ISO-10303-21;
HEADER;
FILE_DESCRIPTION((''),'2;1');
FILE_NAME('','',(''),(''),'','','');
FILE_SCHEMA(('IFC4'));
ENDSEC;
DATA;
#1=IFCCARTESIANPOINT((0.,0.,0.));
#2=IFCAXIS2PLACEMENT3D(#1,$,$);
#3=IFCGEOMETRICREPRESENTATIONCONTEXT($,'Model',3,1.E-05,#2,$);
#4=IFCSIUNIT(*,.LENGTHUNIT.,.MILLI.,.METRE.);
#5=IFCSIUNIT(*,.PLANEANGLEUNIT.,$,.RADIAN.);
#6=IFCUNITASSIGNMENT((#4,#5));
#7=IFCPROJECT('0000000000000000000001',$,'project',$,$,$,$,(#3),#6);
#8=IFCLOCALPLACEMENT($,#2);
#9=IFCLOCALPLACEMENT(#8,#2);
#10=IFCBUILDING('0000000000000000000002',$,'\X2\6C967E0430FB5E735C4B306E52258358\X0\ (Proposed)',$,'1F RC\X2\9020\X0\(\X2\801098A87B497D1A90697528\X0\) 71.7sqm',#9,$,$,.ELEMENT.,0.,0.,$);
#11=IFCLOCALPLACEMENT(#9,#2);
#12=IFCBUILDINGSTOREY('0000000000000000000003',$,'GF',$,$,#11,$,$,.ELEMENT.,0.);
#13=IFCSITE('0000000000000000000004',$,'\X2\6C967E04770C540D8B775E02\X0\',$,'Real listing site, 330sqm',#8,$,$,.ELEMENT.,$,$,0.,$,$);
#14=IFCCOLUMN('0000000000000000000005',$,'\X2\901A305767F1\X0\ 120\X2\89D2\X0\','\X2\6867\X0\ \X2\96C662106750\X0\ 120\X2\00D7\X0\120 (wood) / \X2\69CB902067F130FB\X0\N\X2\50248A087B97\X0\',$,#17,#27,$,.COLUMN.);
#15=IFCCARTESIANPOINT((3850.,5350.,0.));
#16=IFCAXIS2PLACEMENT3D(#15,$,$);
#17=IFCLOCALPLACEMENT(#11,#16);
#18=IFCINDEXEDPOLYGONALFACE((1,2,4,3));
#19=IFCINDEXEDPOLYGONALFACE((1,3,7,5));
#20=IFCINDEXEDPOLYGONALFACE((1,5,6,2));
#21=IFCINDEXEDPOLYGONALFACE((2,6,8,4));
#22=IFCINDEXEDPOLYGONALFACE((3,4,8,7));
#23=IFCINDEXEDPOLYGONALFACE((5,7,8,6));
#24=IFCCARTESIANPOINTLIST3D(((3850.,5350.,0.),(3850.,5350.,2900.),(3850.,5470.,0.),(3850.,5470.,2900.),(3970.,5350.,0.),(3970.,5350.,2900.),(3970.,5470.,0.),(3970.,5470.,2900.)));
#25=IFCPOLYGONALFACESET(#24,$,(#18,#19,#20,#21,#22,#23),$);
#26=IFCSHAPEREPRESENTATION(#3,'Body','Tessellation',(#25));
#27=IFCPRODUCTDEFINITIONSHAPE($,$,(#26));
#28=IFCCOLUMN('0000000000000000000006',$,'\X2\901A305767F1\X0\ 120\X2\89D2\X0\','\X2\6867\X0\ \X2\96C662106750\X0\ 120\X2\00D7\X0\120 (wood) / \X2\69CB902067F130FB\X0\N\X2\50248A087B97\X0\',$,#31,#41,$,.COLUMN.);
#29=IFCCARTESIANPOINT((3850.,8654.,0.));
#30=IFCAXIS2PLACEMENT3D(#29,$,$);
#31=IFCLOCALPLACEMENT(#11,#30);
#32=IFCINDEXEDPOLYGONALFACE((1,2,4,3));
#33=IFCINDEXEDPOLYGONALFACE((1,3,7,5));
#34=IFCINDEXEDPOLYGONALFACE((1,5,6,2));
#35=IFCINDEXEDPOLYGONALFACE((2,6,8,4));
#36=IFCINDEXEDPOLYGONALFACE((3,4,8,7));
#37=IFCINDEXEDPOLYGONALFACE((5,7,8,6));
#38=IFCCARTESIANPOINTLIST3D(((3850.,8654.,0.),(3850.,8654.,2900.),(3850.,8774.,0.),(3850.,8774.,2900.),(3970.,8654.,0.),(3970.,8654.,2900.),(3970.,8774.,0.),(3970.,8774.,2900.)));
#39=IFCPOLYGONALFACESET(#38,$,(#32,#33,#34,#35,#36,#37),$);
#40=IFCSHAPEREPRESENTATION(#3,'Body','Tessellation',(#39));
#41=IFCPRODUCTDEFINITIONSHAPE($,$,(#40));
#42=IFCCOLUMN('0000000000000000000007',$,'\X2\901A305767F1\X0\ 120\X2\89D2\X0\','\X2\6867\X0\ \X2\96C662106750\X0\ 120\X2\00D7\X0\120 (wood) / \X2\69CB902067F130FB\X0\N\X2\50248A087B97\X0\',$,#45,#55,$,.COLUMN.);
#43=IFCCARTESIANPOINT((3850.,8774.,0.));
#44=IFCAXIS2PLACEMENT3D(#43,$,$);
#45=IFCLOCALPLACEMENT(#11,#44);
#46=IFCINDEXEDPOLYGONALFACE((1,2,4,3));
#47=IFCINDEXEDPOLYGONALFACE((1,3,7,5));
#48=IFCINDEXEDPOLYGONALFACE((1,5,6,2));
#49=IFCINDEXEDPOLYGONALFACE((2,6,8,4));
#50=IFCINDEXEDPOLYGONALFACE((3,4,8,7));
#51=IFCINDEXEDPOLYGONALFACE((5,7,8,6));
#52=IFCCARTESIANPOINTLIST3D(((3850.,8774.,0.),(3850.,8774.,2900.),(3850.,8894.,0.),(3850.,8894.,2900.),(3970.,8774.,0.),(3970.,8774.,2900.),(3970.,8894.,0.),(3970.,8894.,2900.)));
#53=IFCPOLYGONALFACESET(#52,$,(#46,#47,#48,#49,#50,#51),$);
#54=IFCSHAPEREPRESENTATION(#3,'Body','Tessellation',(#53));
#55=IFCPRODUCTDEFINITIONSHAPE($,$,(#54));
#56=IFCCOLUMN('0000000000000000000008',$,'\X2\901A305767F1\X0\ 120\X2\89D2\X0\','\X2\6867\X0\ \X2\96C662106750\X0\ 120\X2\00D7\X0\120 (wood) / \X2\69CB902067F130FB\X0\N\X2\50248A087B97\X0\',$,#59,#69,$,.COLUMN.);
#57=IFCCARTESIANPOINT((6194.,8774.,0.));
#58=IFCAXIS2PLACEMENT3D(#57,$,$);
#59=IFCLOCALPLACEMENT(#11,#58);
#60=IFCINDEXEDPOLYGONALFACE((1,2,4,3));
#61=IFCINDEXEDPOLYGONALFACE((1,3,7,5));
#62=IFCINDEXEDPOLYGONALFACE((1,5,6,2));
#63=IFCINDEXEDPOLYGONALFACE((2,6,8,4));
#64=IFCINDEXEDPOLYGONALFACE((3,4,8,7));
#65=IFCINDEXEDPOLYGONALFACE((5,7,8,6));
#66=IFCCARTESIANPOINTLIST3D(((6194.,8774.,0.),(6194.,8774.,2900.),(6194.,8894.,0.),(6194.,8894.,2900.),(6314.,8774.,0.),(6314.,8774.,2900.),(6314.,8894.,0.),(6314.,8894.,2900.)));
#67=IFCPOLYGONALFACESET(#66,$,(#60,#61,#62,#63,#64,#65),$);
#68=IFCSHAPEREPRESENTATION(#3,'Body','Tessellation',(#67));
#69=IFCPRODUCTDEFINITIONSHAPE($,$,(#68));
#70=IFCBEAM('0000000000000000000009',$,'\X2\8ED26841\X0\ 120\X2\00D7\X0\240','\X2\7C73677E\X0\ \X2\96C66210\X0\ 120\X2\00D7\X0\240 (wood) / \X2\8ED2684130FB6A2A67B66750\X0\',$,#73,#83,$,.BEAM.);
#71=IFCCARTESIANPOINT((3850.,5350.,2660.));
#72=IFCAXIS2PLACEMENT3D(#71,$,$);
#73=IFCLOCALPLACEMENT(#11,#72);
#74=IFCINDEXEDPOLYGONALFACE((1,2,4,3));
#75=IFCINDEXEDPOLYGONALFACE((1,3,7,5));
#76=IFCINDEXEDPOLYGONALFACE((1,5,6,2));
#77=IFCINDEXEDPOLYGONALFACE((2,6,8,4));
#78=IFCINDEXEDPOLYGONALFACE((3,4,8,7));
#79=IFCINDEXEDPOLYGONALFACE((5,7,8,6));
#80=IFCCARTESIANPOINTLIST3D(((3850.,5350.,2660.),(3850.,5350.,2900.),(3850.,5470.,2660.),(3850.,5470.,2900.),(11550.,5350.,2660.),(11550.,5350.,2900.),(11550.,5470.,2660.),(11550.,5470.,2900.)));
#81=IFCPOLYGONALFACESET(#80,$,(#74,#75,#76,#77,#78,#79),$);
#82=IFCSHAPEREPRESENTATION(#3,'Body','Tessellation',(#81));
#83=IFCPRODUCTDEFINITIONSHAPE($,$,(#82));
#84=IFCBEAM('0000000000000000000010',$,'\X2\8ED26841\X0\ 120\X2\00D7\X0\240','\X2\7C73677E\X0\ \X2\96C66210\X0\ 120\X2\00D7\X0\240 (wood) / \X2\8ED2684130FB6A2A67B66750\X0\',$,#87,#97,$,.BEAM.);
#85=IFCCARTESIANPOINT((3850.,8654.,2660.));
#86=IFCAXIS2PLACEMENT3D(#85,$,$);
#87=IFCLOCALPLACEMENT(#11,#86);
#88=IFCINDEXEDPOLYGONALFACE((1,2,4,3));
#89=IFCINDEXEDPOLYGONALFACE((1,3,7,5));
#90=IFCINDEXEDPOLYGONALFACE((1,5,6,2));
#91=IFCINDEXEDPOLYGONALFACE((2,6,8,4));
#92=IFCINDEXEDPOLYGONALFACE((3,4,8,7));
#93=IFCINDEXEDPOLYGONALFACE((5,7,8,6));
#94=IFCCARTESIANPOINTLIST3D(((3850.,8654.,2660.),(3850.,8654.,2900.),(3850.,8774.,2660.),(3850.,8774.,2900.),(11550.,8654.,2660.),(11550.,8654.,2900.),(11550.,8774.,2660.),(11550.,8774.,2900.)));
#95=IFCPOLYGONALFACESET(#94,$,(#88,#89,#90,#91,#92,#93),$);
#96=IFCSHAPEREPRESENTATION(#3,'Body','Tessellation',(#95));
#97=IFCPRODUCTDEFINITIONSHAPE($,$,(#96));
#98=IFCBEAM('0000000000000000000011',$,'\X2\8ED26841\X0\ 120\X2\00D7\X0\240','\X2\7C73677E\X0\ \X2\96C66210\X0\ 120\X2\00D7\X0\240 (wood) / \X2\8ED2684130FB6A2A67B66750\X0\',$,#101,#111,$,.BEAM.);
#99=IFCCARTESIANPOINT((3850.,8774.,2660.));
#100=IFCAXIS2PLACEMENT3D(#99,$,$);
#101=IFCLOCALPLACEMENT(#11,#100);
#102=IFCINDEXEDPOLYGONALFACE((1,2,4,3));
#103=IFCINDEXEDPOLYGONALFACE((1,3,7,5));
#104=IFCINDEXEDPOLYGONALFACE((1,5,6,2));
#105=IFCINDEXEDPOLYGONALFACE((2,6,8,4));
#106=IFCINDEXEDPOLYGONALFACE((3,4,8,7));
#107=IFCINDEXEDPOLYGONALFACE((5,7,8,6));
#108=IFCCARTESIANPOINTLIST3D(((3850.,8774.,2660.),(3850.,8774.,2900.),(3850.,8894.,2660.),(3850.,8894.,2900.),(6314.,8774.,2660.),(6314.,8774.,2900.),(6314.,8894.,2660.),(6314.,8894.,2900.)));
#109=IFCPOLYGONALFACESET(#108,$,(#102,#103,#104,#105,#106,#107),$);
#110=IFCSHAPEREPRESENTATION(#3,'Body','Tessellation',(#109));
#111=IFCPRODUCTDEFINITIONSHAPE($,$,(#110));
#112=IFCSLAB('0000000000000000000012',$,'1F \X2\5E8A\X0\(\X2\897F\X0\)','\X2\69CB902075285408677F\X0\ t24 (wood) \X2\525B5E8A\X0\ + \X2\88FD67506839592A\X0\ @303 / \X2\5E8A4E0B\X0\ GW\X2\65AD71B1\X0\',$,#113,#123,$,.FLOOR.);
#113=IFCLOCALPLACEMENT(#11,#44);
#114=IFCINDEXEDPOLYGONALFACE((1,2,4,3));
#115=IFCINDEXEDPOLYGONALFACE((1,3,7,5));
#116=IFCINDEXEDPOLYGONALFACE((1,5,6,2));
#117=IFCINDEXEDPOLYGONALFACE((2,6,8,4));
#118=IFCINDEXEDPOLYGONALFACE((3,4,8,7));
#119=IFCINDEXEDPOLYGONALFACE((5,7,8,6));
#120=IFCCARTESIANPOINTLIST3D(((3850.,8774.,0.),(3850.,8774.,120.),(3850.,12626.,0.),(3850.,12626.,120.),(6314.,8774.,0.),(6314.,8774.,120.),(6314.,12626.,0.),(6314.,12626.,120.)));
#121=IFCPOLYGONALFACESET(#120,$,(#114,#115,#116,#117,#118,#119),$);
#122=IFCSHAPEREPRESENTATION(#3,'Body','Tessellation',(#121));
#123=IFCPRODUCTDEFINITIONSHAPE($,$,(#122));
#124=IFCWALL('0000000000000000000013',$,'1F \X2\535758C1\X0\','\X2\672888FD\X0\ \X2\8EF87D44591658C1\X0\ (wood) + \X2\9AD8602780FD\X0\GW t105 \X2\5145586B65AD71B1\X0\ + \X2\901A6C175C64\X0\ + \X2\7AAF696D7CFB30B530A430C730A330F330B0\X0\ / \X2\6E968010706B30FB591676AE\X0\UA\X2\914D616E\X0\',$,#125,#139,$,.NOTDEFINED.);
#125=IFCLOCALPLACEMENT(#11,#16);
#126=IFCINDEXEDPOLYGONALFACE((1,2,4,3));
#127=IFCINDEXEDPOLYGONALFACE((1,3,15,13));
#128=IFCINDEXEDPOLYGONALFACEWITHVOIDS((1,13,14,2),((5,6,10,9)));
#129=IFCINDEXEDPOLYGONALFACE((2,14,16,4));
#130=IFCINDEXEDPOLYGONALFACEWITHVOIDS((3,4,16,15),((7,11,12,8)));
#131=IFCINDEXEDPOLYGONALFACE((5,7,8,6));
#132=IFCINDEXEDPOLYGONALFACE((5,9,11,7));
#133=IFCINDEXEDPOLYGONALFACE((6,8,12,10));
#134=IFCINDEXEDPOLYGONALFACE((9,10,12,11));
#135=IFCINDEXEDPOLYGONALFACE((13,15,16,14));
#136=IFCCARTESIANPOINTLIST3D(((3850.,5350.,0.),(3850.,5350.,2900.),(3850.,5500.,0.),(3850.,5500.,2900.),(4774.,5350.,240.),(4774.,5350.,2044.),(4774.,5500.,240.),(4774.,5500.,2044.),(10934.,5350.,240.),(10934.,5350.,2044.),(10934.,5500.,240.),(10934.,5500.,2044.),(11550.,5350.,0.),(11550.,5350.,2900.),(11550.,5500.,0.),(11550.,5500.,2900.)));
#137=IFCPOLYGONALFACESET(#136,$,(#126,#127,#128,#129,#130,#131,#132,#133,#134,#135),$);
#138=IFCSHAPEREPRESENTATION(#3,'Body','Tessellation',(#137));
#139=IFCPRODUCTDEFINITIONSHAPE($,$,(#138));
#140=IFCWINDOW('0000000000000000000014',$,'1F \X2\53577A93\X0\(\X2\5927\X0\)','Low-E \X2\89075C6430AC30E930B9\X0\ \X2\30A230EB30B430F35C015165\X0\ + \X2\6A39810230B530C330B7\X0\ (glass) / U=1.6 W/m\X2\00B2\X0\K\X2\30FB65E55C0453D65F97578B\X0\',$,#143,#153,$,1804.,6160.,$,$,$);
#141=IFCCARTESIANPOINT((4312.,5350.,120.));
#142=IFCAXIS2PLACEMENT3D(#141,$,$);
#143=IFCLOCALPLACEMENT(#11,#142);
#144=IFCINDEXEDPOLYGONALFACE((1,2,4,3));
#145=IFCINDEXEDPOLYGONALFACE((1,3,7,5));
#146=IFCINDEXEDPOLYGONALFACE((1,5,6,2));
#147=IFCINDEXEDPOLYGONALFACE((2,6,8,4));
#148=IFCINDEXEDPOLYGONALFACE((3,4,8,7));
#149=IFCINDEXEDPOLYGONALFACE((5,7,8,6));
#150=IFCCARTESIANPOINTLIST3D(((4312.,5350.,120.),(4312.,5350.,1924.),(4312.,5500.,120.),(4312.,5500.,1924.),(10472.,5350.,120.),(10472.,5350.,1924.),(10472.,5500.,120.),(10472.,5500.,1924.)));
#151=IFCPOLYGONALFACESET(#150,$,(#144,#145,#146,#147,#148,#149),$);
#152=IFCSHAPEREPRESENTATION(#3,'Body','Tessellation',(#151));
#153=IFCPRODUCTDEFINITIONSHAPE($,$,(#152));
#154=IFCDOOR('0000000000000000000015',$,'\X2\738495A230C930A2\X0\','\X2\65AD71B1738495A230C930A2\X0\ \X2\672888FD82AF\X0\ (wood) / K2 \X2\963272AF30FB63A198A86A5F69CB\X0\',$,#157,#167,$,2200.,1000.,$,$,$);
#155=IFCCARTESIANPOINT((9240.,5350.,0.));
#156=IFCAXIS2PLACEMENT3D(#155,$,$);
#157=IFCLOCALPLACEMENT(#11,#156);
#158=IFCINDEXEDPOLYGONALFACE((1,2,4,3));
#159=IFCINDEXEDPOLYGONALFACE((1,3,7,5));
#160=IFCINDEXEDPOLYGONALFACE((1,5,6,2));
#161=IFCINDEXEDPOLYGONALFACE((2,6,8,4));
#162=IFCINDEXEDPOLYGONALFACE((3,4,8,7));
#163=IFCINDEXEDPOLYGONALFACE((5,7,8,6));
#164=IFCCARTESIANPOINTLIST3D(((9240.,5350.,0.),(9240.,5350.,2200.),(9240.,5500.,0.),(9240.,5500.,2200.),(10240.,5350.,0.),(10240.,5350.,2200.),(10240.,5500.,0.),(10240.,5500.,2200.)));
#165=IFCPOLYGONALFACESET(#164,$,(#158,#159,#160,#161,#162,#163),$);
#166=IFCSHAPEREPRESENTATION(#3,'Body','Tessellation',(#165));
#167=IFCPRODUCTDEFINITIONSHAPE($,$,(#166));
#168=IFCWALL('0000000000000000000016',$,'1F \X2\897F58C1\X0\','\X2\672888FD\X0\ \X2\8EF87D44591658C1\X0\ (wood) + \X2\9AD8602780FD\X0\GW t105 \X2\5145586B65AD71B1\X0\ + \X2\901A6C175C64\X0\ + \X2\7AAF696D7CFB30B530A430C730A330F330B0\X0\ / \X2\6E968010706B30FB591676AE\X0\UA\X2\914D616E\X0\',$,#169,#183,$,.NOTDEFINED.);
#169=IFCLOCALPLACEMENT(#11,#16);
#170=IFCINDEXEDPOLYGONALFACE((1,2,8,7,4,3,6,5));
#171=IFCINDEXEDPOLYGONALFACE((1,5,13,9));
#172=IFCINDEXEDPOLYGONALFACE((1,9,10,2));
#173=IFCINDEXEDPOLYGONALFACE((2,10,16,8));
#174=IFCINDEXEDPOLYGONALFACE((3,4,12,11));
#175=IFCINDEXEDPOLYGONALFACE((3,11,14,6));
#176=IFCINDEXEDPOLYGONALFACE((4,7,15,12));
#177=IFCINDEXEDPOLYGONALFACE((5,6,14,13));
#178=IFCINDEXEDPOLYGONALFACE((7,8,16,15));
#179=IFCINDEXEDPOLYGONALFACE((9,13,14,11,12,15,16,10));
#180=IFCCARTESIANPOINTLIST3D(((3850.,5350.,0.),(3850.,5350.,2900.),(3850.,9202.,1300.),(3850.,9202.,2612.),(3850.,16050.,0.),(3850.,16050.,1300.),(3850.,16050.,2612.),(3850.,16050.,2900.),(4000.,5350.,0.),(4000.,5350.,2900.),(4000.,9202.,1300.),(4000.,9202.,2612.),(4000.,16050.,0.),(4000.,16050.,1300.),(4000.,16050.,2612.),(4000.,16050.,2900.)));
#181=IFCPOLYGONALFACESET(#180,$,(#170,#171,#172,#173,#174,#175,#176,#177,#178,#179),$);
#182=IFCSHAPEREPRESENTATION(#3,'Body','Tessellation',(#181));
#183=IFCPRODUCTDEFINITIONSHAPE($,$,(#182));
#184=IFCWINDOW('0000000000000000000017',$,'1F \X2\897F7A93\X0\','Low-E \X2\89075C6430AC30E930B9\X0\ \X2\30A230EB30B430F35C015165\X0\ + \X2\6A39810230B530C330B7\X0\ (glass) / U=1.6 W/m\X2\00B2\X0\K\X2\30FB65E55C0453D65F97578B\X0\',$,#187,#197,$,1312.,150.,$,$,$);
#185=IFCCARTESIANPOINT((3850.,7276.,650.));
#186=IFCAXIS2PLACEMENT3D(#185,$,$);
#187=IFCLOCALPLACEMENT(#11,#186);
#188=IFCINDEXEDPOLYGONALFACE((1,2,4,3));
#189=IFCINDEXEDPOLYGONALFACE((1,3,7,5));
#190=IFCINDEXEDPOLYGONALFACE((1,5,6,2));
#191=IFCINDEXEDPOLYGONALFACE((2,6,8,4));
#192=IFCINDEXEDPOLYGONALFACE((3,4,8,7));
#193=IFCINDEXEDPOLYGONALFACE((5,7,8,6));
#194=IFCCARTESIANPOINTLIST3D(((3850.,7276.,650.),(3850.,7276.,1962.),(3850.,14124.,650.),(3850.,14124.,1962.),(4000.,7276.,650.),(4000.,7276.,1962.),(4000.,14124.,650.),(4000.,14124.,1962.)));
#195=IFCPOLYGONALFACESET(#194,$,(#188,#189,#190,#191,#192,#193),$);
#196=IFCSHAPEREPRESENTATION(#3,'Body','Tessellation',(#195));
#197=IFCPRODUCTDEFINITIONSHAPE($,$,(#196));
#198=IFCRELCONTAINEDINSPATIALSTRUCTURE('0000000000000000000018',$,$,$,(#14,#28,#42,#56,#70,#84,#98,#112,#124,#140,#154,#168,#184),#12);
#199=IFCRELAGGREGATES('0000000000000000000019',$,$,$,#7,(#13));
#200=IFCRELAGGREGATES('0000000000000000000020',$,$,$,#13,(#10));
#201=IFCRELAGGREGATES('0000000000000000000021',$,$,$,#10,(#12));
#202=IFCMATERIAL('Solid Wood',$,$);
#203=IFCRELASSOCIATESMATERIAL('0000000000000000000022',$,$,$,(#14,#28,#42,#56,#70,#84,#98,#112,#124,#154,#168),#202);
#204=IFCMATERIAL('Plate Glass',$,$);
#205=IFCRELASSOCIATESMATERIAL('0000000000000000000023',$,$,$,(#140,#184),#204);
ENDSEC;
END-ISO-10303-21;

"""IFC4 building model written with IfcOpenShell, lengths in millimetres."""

from ifc_helpers import new_model, si_unit, frame, frame_2d, origin, place, context, project, spatial, rectangle, extrude, material, element, fill, save


model = new_model("IFC4")

# Units and contexts
model_context = context("Model", 3, precision=1e-05, world=origin())
ifc_project = project(units=[si_unit("LENGTHUNIT", "METRE", prefix="MILLI"), si_unit("PLANEANGLEUNIT", "RADIAN")], contexts=[model_context])

# Site, building, storey
site_placement = place(None, origin())
site = spatial("IfcSite", under=ifc_project, at=site_placement, Name="沖縄県名護市", ObjectType="Real listing site, 330sqm", CompositionType="ELEMENT", RefElevation=0.0)
building_placement = place(site_placement, origin())
building = spatial("IfcBuilding", under=site, at=building_placement, Name="沖縄・平屋の別荘 (Proposed)", ObjectType="1F RC造(耐風等級適用) 71.7sqm", CompositionType="ELEMENT", ElevationOfRefHeight=0.0, ElevationOfTerrain=0.0)
storey_placement = place(building_placement, origin())
storey = spatial("IfcBuildingStorey", under=building, at=storey_placement, Name="GF", CompositionType="ELEMENT", Elevation=0.0)

# Columns
ifc_material_1 = material(Name="Solid Wood")
column_1_placement = place(storey_placement, frame((3850.0, 5350.0, 0.0)))
element("IfcColumn", 1, at=column_1_placement, inside=storey, material=ifc_material_1, Name="通し柱 120角", Description="桧 集成材 120×120 (wood) / 構造柱・N値計算", PredefinedType="COLUMN", context=model_context, shape_type="SweptSolid", body=[
    extrude(rectangle(XDim=120.0, YDim=120.0, at=frame_2d((60.0, 60.0))), frame((3850.0, 5350.0, 0.0)), (0.0, 0.0, 1.0), 2900.0),
])
column_2_placement = place(storey_placement, frame((3850.0, 8654.0, 0.0)))
element("IfcColumn", 2, at=column_2_placement, inside=storey, material=ifc_material_1, Name="通し柱 120角", Description="桧 集成材 120×120 (wood) / 構造柱・N値計算", PredefinedType="COLUMN", context=model_context, shape_type="SweptSolid", body=[
    extrude(rectangle(XDim=120.0, YDim=120.0, at=frame_2d((60.0, 60.0))), frame((3850.0, 8654.0, 0.0)), (0.0, 0.0, 1.0), 2900.0),
])
column_3_placement = place(storey_placement, frame((3850.0, 8774.0, 0.0)))
element("IfcColumn", 3, at=column_3_placement, inside=storey, material=ifc_material_1, Name="通し柱 120角", Description="桧 集成材 120×120 (wood) / 構造柱・N値計算", PredefinedType="COLUMN", context=model_context, shape_type="SweptSolid", body=[
    extrude(rectangle(XDim=120.0, YDim=120.0, at=frame_2d((60.0, 60.0))), frame((3850.0, 8774.0, 0.0)), (0.0, 0.0, 1.0), 2900.0),
])
column_4_placement = place(storey_placement, frame((6194.0, 8774.0, 0.0)))
element("IfcColumn", 4, at=column_4_placement, inside=storey, material=ifc_material_1, Name="通し柱 120角", Description="桧 集成材 120×120 (wood) / 構造柱・N値計算", PredefinedType="COLUMN", context=model_context, shape_type="SweptSolid", body=[
    extrude(rectangle(XDim=120.0, YDim=120.0, at=frame_2d((60.0, 60.0))), frame((6194.0, 8774.0, 0.0)), (0.0, 0.0, 1.0), 2900.0),
])

# Beams
beam_1_placement = place(storey_placement, frame((3850.0, 5350.0, 2660.0)))
element("IfcBeam", 5, at=beam_1_placement, inside=storey, material=ifc_material_1, Name="軒桁 120×240", Description="米松 集成 120×240 (wood) / 軒桁・横架材", PredefinedType="BEAM", context=model_context, shape_type="SweptSolid", body=[
    extrude(rectangle(XDim=7700.0, YDim=120.0, at=frame_2d((3850.0, 60.0))), frame((3850.0, 5350.0, 2660.0)), (0.0, 0.0, 1.0), 240.0),
])
beam_2_placement = place(storey_placement, frame((3850.0, 8654.0, 2660.0)))
element("IfcBeam", 6, at=beam_2_placement, inside=storey, material=ifc_material_1, Name="軒桁 120×240", Description="米松 集成 120×240 (wood) / 軒桁・横架材", PredefinedType="BEAM", context=model_context, shape_type="SweptSolid", body=[
    extrude(rectangle(XDim=7700.0, YDim=120.0, at=frame_2d((3850.0, 60.0))), frame((3850.0, 8654.0, 2660.0)), (0.0, 0.0, 1.0), 240.0),
])
beam_3_placement = place(storey_placement, frame((3850.0, 8774.0, 2660.0)))
element("IfcBeam", 7, at=beam_3_placement, inside=storey, material=ifc_material_1, Name="軒桁 120×240", Description="米松 集成 120×240 (wood) / 軒桁・横架材", PredefinedType="BEAM", context=model_context, shape_type="SweptSolid", body=[
    extrude(rectangle(XDim=2464.0, YDim=120.0, at=frame_2d((1232.0, 60.0))), frame((3850.0, 8774.0, 2660.0)), (0.0, 0.0, 1.0), 240.0),
])

# Slab
slab_1_placement = place(storey_placement, frame((3850.0, 8774.0, 0.0)))
element("IfcSlab", 8, at=slab_1_placement, inside=storey, material=ifc_material_1, Name="1F 床(西)", Description="構造用合板 t24 (wood) 剛床 + 製材根太 @303 / 床下 GW断熱", PredefinedType="FLOOR", context=model_context, shape_type="SweptSolid", body=[
    extrude(rectangle(XDim=2464.0, YDim=3852.0, at=frame_2d((1232.0, 1926.0))), frame((3850.0, 8774.0, 0.0)), (0.0, 0.0, 1.0), 120.0),
])

# Wall, openings, window, door
wall_1_placement = place(storey_placement, frame((3850.0, 5350.0, 0.0)))
wall_1 = element("IfcWall", 9, at=wall_1_placement, inside=storey, material=ifc_material_1, Name="1F 南壁", Description="木製 軸組外壁 (wood) + 高性能GW t105 充填断熱 + 通気層 + 窯業系サイディング / 準耐火・外皮UA配慮", PredefinedType="NOTDEFINED", context=model_context, shape_type="SweptSolid", body=[
    extrude(rectangle(XDim=7700.0, YDim=150.0, at=frame_2d((3850.0, 75.0))), frame((3850.0, 5350.0, 0.0)), (0.0, 0.0, 1.0), 2900.0),
])
opening_1_placement = place(storey_placement, frame((4312.0, 5350.0, 120.0)))
opening_1 = element("IfcOpeningElement", 10, at=opening_1_placement, cuts=wall_1, PredefinedType="NOTDEFINED", context=model_context, shape_type="SweptSolid", body=[
    extrude(rectangle(XDim=6160.0, YDim=150.0, at=frame_2d((3080.0, 75.0))), frame((4312.0, 5350.0, 120.0)), (0.0, 0.0, 1.0), 1804.0),
])
opening_2_placement = place(storey_placement, frame((9240.0, 5350.0, 0.0)))
opening_2 = element("IfcOpeningElement", 11, at=opening_2_placement, cuts=wall_1, PredefinedType="NOTDEFINED", context=model_context, shape_type="SweptSolid", body=[
    extrude(rectangle(XDim=1000.0, YDim=150.0, at=frame_2d((500.0, 75.0))), frame((9240.0, 5350.0, 0.0)), (0.0, 0.0, 1.0), 2200.0),
])
ifc_material_2 = material(Name="Plate Glass")
window_1_placement = place(storey_placement, frame((4312.0, 5350.0, 120.0)))
window_1 = element("IfcWindow", 12, at=window_1_placement, inside=storey, material=ifc_material_2, Name="1F 南窓(大)", Description="Low-E 複層ガラス アルゴン封入 + 樹脂サッシ (glass) / U=1.6 W/m²K・日射取得型", OverallHeight=1804.0, OverallWidth=6160.0, context=model_context, shape_type="SweptSolid", body=[
    extrude(rectangle(XDim=6160.0, YDim=150.0, at=frame_2d((3080.0, 75.0))), frame((4312.0, 5350.0, 120.0)), (0.0, 0.0, 1.0), 1804.0),
])
fill(opening_1, window_1)
door_placement = place(storey_placement, frame((9240.0, 5350.0, 0.0)))
door = element("IfcDoor", 13, at=door_placement, inside=storey, material=ifc_material_1, Name="玄関ドア", Description="断熱玄関ドア 木製芯 (wood) / K2 防犯・採風機構", OverallHeight=2200.0, OverallWidth=1000.0, context=model_context, shape_type="SweptSolid", body=[
    extrude(rectangle(XDim=1000.0, YDim=150.0, at=frame_2d((500.0, 75.0))), frame((9240.0, 5350.0, 0.0)), (0.0, 0.0, 1.0), 2200.0),
])
fill(opening_2, door)

# Wall, opening, window
wall_2_placement = place(storey_placement, frame((3850.0, 5350.0, 0.0)))
wall_2 = element("IfcWall", 14, at=wall_2_placement, inside=storey, material=ifc_material_1, Name="1F 西壁", Description="木製 軸組外壁 (wood) + 高性能GW t105 充填断熱 + 通気層 + 窯業系サイディング / 準耐火・外皮UA配慮", PredefinedType="NOTDEFINED", context=model_context, shape_type="SweptSolid", body=[
    extrude(rectangle(XDim=150.0, YDim=10700.0, at=frame_2d((75.0, 5350.0))), frame((3850.0, 5350.0, 0.0)), (0.0, 0.0, 1.0), 2900.0),
])
opening_3_placement = place(storey_placement, frame((3850.0, 7276.0, 650.0)))
opening_3 = element("IfcOpeningElement", 15, at=opening_3_placement, cuts=wall_2, PredefinedType="NOTDEFINED", context=model_context, shape_type="SweptSolid", body=[
    extrude(rectangle(XDim=150.0, YDim=6848.0, at=frame_2d((75.0, 3424.0))), frame((3850.0, 7276.0, 650.0)), (0.0, 0.0, 1.0), 1312.0),
])
window_2_placement = place(storey_placement, frame((3850.0, 7276.0, 650.0)))
window_2 = element("IfcWindow", 16, at=window_2_placement, inside=storey, material=ifc_material_2, Name="1F 西窓", Description="Low-E 複層ガラス アルゴン封入 + 樹脂サッシ (glass) / U=1.6 W/m²K・日射取得型", OverallHeight=1312.0, OverallWidth=150.0, context=model_context, shape_type="SweptSolid", body=[
    extrude(rectangle(XDim=150.0, YDim=6848.0, at=frame_2d((75.0, 3424.0))), frame((3850.0, 7276.0, 650.0)), (0.0, 0.0, 1.0), 1312.0),
])
fill(opening_3, window_2)

save(model, "model.ifc")
